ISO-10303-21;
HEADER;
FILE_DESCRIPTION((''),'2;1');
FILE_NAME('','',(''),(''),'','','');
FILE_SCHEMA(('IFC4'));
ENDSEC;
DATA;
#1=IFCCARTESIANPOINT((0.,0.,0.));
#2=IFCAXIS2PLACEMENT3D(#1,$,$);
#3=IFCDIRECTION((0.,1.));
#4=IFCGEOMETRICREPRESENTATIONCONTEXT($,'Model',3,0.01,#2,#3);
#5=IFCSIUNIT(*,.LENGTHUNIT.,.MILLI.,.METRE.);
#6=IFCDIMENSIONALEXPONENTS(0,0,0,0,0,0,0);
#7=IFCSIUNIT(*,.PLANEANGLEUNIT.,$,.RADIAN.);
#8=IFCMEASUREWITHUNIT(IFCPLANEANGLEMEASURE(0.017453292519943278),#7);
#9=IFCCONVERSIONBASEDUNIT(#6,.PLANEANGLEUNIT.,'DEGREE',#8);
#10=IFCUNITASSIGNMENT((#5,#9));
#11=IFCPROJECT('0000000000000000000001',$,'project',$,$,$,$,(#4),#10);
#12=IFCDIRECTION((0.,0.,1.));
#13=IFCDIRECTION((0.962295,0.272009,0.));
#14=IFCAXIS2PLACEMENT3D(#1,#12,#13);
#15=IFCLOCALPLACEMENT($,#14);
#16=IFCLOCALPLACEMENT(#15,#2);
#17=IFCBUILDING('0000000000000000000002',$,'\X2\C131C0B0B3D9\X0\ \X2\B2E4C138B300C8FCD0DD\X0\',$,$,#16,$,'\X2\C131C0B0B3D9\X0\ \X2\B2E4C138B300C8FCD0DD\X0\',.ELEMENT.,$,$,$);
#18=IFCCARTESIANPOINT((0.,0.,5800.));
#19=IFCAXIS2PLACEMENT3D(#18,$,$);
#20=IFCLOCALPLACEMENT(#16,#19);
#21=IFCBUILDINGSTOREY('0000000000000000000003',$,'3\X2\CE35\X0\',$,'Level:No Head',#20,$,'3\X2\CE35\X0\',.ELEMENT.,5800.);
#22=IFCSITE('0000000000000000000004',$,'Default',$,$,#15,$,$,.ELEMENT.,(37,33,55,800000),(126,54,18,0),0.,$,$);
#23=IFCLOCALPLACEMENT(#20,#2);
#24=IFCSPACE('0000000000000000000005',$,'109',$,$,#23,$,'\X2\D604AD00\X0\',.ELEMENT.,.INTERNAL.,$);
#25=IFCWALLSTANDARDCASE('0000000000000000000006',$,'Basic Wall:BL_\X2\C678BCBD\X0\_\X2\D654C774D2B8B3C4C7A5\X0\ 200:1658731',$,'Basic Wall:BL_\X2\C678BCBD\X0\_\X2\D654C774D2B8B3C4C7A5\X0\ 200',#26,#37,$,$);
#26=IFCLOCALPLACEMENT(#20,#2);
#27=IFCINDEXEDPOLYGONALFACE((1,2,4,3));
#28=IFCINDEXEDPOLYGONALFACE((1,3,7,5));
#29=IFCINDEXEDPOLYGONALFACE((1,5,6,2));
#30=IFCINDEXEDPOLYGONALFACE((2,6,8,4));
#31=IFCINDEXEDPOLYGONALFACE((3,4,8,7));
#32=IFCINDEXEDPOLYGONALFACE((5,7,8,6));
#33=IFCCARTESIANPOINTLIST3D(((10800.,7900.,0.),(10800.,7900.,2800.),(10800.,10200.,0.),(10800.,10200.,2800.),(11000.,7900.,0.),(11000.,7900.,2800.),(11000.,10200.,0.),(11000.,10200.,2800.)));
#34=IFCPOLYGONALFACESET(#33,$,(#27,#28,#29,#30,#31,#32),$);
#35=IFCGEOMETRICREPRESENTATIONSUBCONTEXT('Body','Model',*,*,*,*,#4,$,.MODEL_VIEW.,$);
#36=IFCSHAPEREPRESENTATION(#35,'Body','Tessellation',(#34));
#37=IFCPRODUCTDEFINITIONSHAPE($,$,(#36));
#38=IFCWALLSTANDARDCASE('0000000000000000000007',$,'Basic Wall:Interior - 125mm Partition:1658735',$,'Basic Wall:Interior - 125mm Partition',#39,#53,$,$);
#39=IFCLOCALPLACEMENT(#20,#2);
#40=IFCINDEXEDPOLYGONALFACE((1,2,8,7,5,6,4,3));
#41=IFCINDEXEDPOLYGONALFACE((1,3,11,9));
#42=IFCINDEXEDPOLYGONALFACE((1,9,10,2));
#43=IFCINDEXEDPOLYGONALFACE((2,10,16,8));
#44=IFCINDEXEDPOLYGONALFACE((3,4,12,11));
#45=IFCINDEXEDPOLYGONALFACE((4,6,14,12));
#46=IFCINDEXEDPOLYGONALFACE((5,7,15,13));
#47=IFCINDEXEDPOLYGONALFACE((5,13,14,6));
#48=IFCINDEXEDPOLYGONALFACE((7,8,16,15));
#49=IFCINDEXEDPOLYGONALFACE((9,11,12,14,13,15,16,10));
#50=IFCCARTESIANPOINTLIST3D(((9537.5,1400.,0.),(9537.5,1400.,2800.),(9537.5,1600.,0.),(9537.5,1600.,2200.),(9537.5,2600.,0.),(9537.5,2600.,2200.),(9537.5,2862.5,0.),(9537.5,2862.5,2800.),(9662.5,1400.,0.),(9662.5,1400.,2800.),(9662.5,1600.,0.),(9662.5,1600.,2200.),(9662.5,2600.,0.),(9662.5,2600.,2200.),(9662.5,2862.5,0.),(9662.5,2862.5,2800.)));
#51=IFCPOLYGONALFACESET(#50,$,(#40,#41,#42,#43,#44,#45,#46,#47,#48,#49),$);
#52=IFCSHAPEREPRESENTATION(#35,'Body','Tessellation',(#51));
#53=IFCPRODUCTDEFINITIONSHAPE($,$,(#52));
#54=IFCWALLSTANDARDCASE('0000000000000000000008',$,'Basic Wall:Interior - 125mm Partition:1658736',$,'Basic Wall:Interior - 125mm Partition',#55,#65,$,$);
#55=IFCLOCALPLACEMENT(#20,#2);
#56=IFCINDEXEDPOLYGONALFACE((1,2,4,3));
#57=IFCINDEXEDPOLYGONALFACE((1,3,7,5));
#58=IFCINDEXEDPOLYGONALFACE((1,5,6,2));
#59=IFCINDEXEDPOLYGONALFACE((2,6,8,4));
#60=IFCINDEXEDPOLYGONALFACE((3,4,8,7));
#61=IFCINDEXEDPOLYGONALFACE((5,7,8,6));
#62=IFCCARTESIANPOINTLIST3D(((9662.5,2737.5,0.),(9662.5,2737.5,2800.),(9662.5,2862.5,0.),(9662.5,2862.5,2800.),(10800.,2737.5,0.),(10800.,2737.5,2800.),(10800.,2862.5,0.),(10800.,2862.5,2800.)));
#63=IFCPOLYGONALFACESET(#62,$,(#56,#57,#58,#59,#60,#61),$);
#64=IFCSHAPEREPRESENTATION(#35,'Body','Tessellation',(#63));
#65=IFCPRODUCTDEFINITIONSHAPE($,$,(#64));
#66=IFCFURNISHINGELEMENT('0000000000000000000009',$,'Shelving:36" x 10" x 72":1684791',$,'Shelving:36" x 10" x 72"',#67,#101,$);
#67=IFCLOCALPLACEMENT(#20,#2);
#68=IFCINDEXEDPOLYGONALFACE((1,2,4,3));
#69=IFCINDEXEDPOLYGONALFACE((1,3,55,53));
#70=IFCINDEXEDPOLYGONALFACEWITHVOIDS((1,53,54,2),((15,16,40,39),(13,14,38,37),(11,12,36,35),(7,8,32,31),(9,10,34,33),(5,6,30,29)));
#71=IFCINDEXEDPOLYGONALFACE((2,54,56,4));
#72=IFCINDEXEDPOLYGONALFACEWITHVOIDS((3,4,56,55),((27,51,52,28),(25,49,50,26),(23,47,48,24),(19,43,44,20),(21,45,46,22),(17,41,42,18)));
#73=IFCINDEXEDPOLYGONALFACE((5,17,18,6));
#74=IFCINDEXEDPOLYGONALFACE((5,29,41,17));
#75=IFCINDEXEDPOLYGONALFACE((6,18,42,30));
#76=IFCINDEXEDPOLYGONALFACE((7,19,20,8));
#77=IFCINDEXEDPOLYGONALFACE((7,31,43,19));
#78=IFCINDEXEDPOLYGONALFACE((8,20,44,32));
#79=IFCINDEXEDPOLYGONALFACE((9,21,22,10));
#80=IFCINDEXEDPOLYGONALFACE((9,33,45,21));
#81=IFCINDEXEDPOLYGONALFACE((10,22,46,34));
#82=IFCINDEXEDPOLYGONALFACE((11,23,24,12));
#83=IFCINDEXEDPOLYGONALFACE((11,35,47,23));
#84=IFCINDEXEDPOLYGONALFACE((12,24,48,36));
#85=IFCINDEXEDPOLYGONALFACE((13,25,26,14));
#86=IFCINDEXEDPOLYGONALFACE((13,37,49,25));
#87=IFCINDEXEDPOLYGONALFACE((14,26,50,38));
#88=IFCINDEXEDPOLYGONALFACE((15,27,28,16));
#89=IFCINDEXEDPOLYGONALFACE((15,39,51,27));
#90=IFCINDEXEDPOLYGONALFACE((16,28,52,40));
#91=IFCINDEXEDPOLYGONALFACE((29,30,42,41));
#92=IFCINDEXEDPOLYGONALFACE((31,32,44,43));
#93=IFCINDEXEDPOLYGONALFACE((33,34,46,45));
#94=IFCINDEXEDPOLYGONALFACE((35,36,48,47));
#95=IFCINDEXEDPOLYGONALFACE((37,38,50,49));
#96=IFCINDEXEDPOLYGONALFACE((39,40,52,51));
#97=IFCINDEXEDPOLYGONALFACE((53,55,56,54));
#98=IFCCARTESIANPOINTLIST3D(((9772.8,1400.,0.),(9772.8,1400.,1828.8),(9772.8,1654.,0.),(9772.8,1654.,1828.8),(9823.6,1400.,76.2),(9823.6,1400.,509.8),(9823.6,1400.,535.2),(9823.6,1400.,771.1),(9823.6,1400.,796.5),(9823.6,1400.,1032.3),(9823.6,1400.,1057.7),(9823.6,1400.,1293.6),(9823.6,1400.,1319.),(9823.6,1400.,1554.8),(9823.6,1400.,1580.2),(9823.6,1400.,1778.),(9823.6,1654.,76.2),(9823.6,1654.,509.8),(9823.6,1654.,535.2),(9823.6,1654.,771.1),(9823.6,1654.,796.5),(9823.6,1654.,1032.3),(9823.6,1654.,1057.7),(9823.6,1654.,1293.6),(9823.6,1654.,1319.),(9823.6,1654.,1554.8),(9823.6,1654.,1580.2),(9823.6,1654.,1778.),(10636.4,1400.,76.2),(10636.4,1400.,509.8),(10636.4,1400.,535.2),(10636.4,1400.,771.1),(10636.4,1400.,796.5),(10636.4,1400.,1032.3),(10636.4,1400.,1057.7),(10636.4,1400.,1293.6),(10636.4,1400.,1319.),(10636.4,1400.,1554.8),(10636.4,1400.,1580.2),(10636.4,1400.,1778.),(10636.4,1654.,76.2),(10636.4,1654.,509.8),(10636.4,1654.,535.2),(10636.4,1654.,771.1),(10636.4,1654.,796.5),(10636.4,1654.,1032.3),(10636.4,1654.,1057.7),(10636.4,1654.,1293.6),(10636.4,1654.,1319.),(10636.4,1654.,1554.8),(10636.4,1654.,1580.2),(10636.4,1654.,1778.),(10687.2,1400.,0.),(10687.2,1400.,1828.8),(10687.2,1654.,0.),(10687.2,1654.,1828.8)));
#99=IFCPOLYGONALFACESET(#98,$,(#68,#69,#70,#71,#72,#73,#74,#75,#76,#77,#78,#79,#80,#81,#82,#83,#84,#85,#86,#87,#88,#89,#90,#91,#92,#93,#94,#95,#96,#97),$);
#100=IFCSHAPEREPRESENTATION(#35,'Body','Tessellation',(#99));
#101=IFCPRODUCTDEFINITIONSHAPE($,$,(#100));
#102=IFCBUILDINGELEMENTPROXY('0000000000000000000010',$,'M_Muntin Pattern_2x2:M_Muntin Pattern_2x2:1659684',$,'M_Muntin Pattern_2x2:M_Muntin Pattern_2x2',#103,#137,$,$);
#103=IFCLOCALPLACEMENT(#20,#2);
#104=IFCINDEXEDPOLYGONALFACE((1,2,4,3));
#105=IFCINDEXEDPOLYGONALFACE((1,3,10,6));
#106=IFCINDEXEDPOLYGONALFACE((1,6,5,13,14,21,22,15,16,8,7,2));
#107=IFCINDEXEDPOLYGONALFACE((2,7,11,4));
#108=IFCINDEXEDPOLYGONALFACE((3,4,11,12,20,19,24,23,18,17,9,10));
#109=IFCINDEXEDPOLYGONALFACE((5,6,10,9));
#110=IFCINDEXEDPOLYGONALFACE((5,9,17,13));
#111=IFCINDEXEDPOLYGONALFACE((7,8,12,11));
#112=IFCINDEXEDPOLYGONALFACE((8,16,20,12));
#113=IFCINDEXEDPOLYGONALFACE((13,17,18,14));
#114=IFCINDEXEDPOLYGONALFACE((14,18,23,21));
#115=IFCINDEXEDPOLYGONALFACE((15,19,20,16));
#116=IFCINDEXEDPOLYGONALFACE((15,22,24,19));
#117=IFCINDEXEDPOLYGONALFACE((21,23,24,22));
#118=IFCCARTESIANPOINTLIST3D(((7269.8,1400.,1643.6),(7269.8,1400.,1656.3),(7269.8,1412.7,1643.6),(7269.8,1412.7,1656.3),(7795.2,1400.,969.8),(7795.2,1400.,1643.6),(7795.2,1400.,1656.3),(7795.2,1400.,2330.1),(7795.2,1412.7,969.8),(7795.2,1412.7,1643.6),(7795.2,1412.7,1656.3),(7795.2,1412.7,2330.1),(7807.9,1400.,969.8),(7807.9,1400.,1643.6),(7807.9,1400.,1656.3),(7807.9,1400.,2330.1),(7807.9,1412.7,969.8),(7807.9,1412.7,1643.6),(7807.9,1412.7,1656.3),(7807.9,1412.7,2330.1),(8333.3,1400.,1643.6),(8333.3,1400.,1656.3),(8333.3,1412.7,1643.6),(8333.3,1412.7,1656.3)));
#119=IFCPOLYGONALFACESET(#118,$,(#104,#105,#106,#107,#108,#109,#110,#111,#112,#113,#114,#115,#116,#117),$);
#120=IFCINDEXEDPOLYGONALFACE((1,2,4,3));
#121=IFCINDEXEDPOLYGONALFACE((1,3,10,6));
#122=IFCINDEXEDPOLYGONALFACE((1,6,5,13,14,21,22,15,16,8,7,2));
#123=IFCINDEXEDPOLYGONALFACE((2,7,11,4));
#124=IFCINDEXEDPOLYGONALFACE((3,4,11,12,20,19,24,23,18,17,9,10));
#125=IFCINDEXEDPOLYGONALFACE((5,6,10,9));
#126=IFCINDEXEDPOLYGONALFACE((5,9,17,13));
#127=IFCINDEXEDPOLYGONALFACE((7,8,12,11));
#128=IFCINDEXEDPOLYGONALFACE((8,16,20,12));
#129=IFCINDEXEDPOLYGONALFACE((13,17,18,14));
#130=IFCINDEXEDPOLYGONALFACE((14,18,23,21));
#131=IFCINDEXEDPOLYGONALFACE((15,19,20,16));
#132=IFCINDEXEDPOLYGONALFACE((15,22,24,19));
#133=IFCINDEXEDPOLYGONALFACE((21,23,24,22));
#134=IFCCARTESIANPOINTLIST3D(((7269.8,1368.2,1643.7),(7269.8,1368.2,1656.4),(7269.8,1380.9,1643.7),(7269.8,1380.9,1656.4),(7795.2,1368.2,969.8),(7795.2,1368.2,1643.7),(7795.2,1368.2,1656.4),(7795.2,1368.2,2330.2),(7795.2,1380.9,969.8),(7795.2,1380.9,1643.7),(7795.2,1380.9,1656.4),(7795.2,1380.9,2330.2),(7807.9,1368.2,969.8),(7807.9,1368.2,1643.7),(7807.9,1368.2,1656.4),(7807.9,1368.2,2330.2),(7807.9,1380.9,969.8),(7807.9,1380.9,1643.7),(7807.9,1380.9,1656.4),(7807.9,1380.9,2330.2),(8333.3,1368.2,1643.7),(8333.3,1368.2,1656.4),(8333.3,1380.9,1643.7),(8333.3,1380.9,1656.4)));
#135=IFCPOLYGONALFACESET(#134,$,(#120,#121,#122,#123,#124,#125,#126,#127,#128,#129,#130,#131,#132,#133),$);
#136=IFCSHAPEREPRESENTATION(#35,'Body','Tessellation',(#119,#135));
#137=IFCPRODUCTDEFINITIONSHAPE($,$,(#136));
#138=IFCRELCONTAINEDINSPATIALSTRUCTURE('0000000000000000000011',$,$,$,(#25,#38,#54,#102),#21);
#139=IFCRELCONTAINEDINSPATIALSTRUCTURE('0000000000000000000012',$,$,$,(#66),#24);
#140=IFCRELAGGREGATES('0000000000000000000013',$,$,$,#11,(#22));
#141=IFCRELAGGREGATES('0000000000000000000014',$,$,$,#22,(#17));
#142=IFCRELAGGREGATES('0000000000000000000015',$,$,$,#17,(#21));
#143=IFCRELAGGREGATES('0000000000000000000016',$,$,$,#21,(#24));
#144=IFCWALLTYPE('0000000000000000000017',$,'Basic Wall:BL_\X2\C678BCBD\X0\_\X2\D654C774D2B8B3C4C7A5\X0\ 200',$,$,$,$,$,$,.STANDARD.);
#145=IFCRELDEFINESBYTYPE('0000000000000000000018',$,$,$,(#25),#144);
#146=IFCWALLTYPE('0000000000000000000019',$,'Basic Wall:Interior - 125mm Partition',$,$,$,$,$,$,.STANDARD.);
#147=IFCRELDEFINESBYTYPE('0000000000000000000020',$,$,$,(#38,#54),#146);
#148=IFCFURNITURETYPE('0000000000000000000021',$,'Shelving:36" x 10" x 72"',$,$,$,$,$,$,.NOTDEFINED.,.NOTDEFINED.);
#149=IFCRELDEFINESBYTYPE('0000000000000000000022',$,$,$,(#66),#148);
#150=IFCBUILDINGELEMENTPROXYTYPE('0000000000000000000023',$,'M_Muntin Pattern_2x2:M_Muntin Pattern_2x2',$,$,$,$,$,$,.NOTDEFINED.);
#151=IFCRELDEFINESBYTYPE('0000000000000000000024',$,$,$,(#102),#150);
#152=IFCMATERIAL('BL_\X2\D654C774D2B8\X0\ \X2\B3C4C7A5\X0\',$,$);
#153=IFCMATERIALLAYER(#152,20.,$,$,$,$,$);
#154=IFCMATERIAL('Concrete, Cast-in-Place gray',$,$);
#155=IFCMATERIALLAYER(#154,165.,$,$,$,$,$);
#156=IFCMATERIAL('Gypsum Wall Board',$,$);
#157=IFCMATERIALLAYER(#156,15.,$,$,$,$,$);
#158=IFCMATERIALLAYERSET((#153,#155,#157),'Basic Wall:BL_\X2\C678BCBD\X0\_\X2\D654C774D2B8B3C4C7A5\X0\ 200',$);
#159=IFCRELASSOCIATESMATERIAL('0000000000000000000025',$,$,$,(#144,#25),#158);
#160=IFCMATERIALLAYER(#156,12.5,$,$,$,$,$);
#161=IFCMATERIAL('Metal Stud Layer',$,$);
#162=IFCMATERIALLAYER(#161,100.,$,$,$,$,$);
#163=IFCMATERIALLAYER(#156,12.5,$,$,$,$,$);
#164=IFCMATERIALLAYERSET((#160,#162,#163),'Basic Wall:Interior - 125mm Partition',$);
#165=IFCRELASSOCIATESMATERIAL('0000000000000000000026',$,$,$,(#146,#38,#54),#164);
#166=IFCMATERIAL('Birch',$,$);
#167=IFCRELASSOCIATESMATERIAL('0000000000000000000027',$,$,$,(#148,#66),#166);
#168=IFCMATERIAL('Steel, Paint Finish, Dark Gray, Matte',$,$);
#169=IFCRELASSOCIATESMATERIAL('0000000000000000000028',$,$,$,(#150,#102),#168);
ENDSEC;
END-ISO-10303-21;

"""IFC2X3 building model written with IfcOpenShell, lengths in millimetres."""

from ifc_helpers import new_model, entity, si_unit, converted_unit, direction, frame, frame_2d, origin, place, context, subcontext, project, spatial, polyline, rectangle, outline, extrude, source, transform, mapped, material, layer, layer_set, layer_usage, type_object, type_shapes, element, save


model = new_model("IFC2X3")

# Units and contexts
model_context = context("Model", 3, precision=0.01, world=origin(), true_north=direction((0.0, 1.0)))
body_context = subcontext(model_context, "Body", "Model", "MODEL_VIEW")
ifc_project = project(units=[si_unit("LENGTHUNIT", "METRE", prefix="MILLI"), converted_unit("PLANEANGLEUNIT", "DEGREE", entity("IfcPlaneAngleMeasure", 0.017453292519943278), si_unit("PLANEANGLEUNIT", "RADIAN"), dimensions=[0, 0, 0, 0, 0, 0, 0])], contexts=[model_context])

# Site, building, storey
site_placement = place(None, frame((0.0, 0.0, 0.0), z_axis=(0.0, 0.0, 1.0), x_axis=(0.962295, 0.272009, 0.0)))
site = spatial("IfcSite", under=ifc_project, at=site_placement, Name="Default", CompositionType="ELEMENT", RefLatitude=(37, 33, 55, 800000), RefLongitude=(126, 54, 18, 0), RefElevation=0.0)
building_placement = place(site_placement, origin())
building = spatial("IfcBuilding", under=site, at=building_placement, Name="성산동 다세대주택", LongName="성산동 다세대주택", CompositionType="ELEMENT")
storey_placement = place(building_placement, frame((0.0, 0.0, 5800.0)))
storey = spatial("IfcBuildingStorey", under=building, at=storey_placement, Name="3층", ObjectType="Level:No Head", LongName="3층", CompositionType="ELEMENT", Elevation=5800.0)

# Shared definitions
ifc_material_1 = material(Name="Steel, Paint Finish, Dark Gray, Matte")
ifc_material_2 = material(Name="Concrete, Cast-in-Place gray")
ifc_material_3 = material(Name="Gypsum Wall Board")

# Wall
ifc_material_4 = material(Name="BL_화이트 도장")
ifc_layer_1 = layer(ifc_material_4, 20.0)
ifc_layer_2 = layer(ifc_material_2, 165.0)
ifc_layer_3 = layer(ifc_material_3, 15.0)
ifc_layer_set_1 = layer_set([ifc_layer_1, ifc_layer_2, ifc_layer_3], Name="Basic Wall:BL_외벽_화이트도장 200")
ifc_layer_usage_1 = layer_usage(ifc_layer_set_1, "AXIS2", "NEGATIVE", 100.0)
wall_type_1 = type_object("IfcWallType", Name="Basic Wall:BL_외벽_화이트도장 200", PredefinedType="STANDARD", material=ifc_layer_set_1)
wall_1_placement = place(storey_placement, frame((10900.0, 10200.0, 0.0), z_axis=(0.0, 0.0, 1.0), x_axis=(0.0, -1.0, 0.0)))
element("IfcWallStandardCase", 1, at=wall_1_placement, inside=storey, type_object=wall_type_1, material=ifc_layer_usage_1, Name="Basic Wall:BL_외벽_화이트도장 200:1658731", ObjectType="Basic Wall:BL_외벽_화이트도장 200", context=body_context, shape_type="SweptSolid", body=[
    extrude(rectangle(XDim=2300.0, YDim=200.0, at=frame_2d((1150.0, 0.0), x_axis=(-1.0, 0.0))), origin(), (0.0, 0.0, 1.0), 2800.0),
])

# Wall, openings
ifc_layer_4 = layer(ifc_material_3, 12.5)
ifc_material_5 = material(Name="Metal Stud Layer")
ifc_layer_5 = layer(ifc_material_5, 100.0)
ifc_layer_6 = layer(ifc_material_3, 12.5)
ifc_layer_set_2 = layer_set([ifc_layer_4, ifc_layer_5, ifc_layer_6], Name="Basic Wall:Interior - 125mm Partition")
ifc_layer_usage_2 = layer_usage(ifc_layer_set_2, "AXIS2", "NEGATIVE", 62.5)
wall_type_2 = type_object("IfcWallType", Name="Basic Wall:Interior - 125mm Partition", PredefinedType="STANDARD", material=ifc_layer_set_2)
wall_2_placement = place(storey_placement, frame((9600.0, 1400.0, 0.0), z_axis=(0.0, 0.0, 1.0), x_axis=(0.0, 1.0, 0.0)))
wall_2 = element("IfcWallStandardCase", 2, at=wall_2_placement, inside=storey, type_object=wall_type_2, material=ifc_layer_usage_2, Name="Basic Wall:Interior - 125mm Partition:1658735", ObjectType="Basic Wall:Interior - 125mm Partition", context=body_context, shape_type="SweptSolid", body=[
    extrude(rectangle(XDim=1462.5, YDim=125.0, at=frame_2d((731.2, 0.0), x_axis=(-1.0, 0.0))), origin(), (0.0, 0.0, 1.0), 2800.0),
])
opening_1_placement = place(wall_2_placement, origin())
element("IfcOpeningElement", 3, at=opening_1_placement, cuts=wall_2, ObjectType="Opening", context=body_context, shape_type="SweptSolid", body=[
    extrude(rectangle(XDim=2200.0, YDim=1000.0, at=frame_2d((0.0, 0.0), x_axis=(0.0, 1.0))), frame((700.0, -1586.5, 3900.0), z_axis=(0.0, 1.0, 0.0), x_axis=(-1.0, 0.0, 0.0)), (0.0, 0.0, 1.0), 3048.0),
])
opening_2_placement = place(wall_2_placement, frame((200.0, -62.5, 0.0)))
element("IfcOpeningElement", 4, at=opening_2_placement, cuts=wall_2, ObjectType="Opening", context=body_context, shape_type="SweptSolid", body=[
    extrude(rectangle(XDim=2200.0, YDim=1000.0, at=frame_2d((1100.0, 500.0), x_axis=(1.0, 0.0))), frame((0.0, 0.0, 0.0), z_axis=(0.0, 1.0, 0.0), x_axis=(0.0, 0.0, 1.0)), (0.0, 0.0, 1.0), 125.0),
])

# Wall
ifc_layer_usage_3 = layer_usage(ifc_layer_set_2, "AXIS2", "NEGATIVE", 62.5)
wall_3_placement = place(storey_placement, frame((9662.5, 2800.0, 0.0)))
element("IfcWallStandardCase", 5, at=wall_3_placement, inside=storey, type_object=wall_type_2, material=ifc_layer_usage_3, Name="Basic Wall:Interior - 125mm Partition:1658736", ObjectType="Basic Wall:Interior - 125mm Partition", context=body_context, shape_type="SweptSolid", body=[
    extrude(rectangle(XDim=1137.5, YDim=125.0, at=frame_2d((568.7, 0.0), x_axis=(-1.0, 0.0))), origin(), (0.0, 0.0, 1.0), 2800.0),
])

# Shared definitions
space_1_placement = place(storey_placement, origin())
space_1 = spatial("IfcSpace", under=storey, at=space_1_placement, Name="109", LongName="현관", CompositionType="ELEMENT", InteriorOrExteriorSpace="INTERNAL")

# Furnishing element
ifc_material_6 = material(Name="Birch")
furniture_type_1 = type_object("IfcFurnitureType", Name="Shelving:36\" x 10\" x 72\"", AssemblyPlace="NOTDEFINED", material=ifc_material_6)
shared_shape_1 = source(origin(), body_context, "Body", "SweptSolid", [
    extrude(outline(polyline([(-457.2, -914.4), (457.2, -914.4), (457.2, 914.4), (-457.2, 914.4), (-457.2, -914.4)]), holes=[polyline([(-406.4, 863.6), (406.4, 863.6), (406.4, 665.8), (-406.4, 665.8), (-406.4, 863.6)]), polyline([(-406.4, -838.2), (-406.4, -404.6), (406.4, -404.6), (406.4, -838.2), (-406.4, -838.2)]), polyline([(406.4, 143.3), (-406.4, 143.3), (-406.4, 379.2), (406.4, 379.2), (406.4, 143.3)]), polyline([(-406.4, 640.4), (406.4, 640.4), (406.4, 404.6), (-406.4, 404.6), (-406.4, 640.4)]), polyline([(-406.4, 117.9), (406.4, 117.9), (406.4, -117.9), (-406.4, -117.9), (-406.4, 117.9)]), polyline([(-406.4, -143.3), (406.4, -143.3), (406.4, -379.2), (-406.4, -379.2), (-406.4, -143.3)])]), frame((0.0, -431.8, 914.4), z_axis=(0.0, 1.0, 0.0), x_axis=(-1.0, 0.0, 0.0)), (0.0, 0.0, 1.0), 254.0),
])
type_shapes(furniture_type_1, [shared_shape_1])
furnishing_1_placement = place(space_1_placement, frame((10230.0, 1222.2, 0.0), z_axis=(0.0, 0.0, 1.0), x_axis=(-1.0, 0.0, 0.0)))
element("IfcFurnishingElement", 6, at=furnishing_1_placement, inside=space_1, type_object=furniture_type_1, material=ifc_material_6, Name="Shelving:36\" x 10\" x 72\":1684791", ObjectType="Shelving:36\" x 10\" x 72\"", context=body_context, shape_type="MappedRepresentation", body=[
    mapped(shared_shape_1, transform((0.0, 0.0, 0.0), scale=1.0)),
])

# Building element proxy
building_element_proxy_type_1 = type_object("IfcBuildingElementProxyType", Name="M_Muntin Pattern_2x2:M_Muntin Pattern_2x2", PredefinedType="NOTDEFINED", material=ifc_material_1)
shared_shape_2 = source(origin(), body_context, "Body", "SweptSolid", [
    extrude(outline(polyline([(6.4, -6.4), (680.1, -6.4), (680.1, 6.3), (6.4, 6.3), (6.4, 531.7), (-6.3, 531.7), (-6.3, 6.3), (-680.2, 6.3), (-680.2, -6.4), (-6.3, -6.4), (-6.3, -531.7), (6.4, -531.7), (6.4, -6.4)])), frame((0.0, 9.5, 680.1), z_axis=(0.0, 1.0, 0.0), x_axis=(0.0, 0.0, 1.0)), (0.0, 0.0, 1.0), 12.7),
    extrude(outline(polyline([(6.4, -6.4), (680.2, -6.4), (680.2, 6.3), (6.4, 6.3), (6.4, 531.7), (-6.3, 531.7), (-6.3, 6.3), (-680.2, 6.3), (-680.2, -6.4), (-6.3, -6.4), (-6.3, -531.7), (6.4, -531.7), (6.4, -6.4)])), frame((0.0, -22.2, 680.2), z_axis=(0.0, 1.0, 0.0), x_axis=(0.0, 0.0, 1.0)), (0.0, 0.0, 1.0), 12.7),
])
type_shapes(building_element_proxy_type_1, [shared_shape_2])
proxy_1_placement = place(storey_placement, frame((7801.6, 1390.5, 969.8)))
element("IfcBuildingElementProxy", 7, at=proxy_1_placement, inside=storey, type_object=building_element_proxy_type_1, material=ifc_material_1, Name="M_Muntin Pattern_2x2:M_Muntin Pattern_2x2:1659684", ObjectType="M_Muntin Pattern_2x2:M_Muntin Pattern_2x2", context=body_context, shape_type="MappedRepresentation", body=[
    mapped(shared_shape_2, transform((0.0, 0.0, 0.0), scale=1.0)),
])

save(model, "model.ifc")
